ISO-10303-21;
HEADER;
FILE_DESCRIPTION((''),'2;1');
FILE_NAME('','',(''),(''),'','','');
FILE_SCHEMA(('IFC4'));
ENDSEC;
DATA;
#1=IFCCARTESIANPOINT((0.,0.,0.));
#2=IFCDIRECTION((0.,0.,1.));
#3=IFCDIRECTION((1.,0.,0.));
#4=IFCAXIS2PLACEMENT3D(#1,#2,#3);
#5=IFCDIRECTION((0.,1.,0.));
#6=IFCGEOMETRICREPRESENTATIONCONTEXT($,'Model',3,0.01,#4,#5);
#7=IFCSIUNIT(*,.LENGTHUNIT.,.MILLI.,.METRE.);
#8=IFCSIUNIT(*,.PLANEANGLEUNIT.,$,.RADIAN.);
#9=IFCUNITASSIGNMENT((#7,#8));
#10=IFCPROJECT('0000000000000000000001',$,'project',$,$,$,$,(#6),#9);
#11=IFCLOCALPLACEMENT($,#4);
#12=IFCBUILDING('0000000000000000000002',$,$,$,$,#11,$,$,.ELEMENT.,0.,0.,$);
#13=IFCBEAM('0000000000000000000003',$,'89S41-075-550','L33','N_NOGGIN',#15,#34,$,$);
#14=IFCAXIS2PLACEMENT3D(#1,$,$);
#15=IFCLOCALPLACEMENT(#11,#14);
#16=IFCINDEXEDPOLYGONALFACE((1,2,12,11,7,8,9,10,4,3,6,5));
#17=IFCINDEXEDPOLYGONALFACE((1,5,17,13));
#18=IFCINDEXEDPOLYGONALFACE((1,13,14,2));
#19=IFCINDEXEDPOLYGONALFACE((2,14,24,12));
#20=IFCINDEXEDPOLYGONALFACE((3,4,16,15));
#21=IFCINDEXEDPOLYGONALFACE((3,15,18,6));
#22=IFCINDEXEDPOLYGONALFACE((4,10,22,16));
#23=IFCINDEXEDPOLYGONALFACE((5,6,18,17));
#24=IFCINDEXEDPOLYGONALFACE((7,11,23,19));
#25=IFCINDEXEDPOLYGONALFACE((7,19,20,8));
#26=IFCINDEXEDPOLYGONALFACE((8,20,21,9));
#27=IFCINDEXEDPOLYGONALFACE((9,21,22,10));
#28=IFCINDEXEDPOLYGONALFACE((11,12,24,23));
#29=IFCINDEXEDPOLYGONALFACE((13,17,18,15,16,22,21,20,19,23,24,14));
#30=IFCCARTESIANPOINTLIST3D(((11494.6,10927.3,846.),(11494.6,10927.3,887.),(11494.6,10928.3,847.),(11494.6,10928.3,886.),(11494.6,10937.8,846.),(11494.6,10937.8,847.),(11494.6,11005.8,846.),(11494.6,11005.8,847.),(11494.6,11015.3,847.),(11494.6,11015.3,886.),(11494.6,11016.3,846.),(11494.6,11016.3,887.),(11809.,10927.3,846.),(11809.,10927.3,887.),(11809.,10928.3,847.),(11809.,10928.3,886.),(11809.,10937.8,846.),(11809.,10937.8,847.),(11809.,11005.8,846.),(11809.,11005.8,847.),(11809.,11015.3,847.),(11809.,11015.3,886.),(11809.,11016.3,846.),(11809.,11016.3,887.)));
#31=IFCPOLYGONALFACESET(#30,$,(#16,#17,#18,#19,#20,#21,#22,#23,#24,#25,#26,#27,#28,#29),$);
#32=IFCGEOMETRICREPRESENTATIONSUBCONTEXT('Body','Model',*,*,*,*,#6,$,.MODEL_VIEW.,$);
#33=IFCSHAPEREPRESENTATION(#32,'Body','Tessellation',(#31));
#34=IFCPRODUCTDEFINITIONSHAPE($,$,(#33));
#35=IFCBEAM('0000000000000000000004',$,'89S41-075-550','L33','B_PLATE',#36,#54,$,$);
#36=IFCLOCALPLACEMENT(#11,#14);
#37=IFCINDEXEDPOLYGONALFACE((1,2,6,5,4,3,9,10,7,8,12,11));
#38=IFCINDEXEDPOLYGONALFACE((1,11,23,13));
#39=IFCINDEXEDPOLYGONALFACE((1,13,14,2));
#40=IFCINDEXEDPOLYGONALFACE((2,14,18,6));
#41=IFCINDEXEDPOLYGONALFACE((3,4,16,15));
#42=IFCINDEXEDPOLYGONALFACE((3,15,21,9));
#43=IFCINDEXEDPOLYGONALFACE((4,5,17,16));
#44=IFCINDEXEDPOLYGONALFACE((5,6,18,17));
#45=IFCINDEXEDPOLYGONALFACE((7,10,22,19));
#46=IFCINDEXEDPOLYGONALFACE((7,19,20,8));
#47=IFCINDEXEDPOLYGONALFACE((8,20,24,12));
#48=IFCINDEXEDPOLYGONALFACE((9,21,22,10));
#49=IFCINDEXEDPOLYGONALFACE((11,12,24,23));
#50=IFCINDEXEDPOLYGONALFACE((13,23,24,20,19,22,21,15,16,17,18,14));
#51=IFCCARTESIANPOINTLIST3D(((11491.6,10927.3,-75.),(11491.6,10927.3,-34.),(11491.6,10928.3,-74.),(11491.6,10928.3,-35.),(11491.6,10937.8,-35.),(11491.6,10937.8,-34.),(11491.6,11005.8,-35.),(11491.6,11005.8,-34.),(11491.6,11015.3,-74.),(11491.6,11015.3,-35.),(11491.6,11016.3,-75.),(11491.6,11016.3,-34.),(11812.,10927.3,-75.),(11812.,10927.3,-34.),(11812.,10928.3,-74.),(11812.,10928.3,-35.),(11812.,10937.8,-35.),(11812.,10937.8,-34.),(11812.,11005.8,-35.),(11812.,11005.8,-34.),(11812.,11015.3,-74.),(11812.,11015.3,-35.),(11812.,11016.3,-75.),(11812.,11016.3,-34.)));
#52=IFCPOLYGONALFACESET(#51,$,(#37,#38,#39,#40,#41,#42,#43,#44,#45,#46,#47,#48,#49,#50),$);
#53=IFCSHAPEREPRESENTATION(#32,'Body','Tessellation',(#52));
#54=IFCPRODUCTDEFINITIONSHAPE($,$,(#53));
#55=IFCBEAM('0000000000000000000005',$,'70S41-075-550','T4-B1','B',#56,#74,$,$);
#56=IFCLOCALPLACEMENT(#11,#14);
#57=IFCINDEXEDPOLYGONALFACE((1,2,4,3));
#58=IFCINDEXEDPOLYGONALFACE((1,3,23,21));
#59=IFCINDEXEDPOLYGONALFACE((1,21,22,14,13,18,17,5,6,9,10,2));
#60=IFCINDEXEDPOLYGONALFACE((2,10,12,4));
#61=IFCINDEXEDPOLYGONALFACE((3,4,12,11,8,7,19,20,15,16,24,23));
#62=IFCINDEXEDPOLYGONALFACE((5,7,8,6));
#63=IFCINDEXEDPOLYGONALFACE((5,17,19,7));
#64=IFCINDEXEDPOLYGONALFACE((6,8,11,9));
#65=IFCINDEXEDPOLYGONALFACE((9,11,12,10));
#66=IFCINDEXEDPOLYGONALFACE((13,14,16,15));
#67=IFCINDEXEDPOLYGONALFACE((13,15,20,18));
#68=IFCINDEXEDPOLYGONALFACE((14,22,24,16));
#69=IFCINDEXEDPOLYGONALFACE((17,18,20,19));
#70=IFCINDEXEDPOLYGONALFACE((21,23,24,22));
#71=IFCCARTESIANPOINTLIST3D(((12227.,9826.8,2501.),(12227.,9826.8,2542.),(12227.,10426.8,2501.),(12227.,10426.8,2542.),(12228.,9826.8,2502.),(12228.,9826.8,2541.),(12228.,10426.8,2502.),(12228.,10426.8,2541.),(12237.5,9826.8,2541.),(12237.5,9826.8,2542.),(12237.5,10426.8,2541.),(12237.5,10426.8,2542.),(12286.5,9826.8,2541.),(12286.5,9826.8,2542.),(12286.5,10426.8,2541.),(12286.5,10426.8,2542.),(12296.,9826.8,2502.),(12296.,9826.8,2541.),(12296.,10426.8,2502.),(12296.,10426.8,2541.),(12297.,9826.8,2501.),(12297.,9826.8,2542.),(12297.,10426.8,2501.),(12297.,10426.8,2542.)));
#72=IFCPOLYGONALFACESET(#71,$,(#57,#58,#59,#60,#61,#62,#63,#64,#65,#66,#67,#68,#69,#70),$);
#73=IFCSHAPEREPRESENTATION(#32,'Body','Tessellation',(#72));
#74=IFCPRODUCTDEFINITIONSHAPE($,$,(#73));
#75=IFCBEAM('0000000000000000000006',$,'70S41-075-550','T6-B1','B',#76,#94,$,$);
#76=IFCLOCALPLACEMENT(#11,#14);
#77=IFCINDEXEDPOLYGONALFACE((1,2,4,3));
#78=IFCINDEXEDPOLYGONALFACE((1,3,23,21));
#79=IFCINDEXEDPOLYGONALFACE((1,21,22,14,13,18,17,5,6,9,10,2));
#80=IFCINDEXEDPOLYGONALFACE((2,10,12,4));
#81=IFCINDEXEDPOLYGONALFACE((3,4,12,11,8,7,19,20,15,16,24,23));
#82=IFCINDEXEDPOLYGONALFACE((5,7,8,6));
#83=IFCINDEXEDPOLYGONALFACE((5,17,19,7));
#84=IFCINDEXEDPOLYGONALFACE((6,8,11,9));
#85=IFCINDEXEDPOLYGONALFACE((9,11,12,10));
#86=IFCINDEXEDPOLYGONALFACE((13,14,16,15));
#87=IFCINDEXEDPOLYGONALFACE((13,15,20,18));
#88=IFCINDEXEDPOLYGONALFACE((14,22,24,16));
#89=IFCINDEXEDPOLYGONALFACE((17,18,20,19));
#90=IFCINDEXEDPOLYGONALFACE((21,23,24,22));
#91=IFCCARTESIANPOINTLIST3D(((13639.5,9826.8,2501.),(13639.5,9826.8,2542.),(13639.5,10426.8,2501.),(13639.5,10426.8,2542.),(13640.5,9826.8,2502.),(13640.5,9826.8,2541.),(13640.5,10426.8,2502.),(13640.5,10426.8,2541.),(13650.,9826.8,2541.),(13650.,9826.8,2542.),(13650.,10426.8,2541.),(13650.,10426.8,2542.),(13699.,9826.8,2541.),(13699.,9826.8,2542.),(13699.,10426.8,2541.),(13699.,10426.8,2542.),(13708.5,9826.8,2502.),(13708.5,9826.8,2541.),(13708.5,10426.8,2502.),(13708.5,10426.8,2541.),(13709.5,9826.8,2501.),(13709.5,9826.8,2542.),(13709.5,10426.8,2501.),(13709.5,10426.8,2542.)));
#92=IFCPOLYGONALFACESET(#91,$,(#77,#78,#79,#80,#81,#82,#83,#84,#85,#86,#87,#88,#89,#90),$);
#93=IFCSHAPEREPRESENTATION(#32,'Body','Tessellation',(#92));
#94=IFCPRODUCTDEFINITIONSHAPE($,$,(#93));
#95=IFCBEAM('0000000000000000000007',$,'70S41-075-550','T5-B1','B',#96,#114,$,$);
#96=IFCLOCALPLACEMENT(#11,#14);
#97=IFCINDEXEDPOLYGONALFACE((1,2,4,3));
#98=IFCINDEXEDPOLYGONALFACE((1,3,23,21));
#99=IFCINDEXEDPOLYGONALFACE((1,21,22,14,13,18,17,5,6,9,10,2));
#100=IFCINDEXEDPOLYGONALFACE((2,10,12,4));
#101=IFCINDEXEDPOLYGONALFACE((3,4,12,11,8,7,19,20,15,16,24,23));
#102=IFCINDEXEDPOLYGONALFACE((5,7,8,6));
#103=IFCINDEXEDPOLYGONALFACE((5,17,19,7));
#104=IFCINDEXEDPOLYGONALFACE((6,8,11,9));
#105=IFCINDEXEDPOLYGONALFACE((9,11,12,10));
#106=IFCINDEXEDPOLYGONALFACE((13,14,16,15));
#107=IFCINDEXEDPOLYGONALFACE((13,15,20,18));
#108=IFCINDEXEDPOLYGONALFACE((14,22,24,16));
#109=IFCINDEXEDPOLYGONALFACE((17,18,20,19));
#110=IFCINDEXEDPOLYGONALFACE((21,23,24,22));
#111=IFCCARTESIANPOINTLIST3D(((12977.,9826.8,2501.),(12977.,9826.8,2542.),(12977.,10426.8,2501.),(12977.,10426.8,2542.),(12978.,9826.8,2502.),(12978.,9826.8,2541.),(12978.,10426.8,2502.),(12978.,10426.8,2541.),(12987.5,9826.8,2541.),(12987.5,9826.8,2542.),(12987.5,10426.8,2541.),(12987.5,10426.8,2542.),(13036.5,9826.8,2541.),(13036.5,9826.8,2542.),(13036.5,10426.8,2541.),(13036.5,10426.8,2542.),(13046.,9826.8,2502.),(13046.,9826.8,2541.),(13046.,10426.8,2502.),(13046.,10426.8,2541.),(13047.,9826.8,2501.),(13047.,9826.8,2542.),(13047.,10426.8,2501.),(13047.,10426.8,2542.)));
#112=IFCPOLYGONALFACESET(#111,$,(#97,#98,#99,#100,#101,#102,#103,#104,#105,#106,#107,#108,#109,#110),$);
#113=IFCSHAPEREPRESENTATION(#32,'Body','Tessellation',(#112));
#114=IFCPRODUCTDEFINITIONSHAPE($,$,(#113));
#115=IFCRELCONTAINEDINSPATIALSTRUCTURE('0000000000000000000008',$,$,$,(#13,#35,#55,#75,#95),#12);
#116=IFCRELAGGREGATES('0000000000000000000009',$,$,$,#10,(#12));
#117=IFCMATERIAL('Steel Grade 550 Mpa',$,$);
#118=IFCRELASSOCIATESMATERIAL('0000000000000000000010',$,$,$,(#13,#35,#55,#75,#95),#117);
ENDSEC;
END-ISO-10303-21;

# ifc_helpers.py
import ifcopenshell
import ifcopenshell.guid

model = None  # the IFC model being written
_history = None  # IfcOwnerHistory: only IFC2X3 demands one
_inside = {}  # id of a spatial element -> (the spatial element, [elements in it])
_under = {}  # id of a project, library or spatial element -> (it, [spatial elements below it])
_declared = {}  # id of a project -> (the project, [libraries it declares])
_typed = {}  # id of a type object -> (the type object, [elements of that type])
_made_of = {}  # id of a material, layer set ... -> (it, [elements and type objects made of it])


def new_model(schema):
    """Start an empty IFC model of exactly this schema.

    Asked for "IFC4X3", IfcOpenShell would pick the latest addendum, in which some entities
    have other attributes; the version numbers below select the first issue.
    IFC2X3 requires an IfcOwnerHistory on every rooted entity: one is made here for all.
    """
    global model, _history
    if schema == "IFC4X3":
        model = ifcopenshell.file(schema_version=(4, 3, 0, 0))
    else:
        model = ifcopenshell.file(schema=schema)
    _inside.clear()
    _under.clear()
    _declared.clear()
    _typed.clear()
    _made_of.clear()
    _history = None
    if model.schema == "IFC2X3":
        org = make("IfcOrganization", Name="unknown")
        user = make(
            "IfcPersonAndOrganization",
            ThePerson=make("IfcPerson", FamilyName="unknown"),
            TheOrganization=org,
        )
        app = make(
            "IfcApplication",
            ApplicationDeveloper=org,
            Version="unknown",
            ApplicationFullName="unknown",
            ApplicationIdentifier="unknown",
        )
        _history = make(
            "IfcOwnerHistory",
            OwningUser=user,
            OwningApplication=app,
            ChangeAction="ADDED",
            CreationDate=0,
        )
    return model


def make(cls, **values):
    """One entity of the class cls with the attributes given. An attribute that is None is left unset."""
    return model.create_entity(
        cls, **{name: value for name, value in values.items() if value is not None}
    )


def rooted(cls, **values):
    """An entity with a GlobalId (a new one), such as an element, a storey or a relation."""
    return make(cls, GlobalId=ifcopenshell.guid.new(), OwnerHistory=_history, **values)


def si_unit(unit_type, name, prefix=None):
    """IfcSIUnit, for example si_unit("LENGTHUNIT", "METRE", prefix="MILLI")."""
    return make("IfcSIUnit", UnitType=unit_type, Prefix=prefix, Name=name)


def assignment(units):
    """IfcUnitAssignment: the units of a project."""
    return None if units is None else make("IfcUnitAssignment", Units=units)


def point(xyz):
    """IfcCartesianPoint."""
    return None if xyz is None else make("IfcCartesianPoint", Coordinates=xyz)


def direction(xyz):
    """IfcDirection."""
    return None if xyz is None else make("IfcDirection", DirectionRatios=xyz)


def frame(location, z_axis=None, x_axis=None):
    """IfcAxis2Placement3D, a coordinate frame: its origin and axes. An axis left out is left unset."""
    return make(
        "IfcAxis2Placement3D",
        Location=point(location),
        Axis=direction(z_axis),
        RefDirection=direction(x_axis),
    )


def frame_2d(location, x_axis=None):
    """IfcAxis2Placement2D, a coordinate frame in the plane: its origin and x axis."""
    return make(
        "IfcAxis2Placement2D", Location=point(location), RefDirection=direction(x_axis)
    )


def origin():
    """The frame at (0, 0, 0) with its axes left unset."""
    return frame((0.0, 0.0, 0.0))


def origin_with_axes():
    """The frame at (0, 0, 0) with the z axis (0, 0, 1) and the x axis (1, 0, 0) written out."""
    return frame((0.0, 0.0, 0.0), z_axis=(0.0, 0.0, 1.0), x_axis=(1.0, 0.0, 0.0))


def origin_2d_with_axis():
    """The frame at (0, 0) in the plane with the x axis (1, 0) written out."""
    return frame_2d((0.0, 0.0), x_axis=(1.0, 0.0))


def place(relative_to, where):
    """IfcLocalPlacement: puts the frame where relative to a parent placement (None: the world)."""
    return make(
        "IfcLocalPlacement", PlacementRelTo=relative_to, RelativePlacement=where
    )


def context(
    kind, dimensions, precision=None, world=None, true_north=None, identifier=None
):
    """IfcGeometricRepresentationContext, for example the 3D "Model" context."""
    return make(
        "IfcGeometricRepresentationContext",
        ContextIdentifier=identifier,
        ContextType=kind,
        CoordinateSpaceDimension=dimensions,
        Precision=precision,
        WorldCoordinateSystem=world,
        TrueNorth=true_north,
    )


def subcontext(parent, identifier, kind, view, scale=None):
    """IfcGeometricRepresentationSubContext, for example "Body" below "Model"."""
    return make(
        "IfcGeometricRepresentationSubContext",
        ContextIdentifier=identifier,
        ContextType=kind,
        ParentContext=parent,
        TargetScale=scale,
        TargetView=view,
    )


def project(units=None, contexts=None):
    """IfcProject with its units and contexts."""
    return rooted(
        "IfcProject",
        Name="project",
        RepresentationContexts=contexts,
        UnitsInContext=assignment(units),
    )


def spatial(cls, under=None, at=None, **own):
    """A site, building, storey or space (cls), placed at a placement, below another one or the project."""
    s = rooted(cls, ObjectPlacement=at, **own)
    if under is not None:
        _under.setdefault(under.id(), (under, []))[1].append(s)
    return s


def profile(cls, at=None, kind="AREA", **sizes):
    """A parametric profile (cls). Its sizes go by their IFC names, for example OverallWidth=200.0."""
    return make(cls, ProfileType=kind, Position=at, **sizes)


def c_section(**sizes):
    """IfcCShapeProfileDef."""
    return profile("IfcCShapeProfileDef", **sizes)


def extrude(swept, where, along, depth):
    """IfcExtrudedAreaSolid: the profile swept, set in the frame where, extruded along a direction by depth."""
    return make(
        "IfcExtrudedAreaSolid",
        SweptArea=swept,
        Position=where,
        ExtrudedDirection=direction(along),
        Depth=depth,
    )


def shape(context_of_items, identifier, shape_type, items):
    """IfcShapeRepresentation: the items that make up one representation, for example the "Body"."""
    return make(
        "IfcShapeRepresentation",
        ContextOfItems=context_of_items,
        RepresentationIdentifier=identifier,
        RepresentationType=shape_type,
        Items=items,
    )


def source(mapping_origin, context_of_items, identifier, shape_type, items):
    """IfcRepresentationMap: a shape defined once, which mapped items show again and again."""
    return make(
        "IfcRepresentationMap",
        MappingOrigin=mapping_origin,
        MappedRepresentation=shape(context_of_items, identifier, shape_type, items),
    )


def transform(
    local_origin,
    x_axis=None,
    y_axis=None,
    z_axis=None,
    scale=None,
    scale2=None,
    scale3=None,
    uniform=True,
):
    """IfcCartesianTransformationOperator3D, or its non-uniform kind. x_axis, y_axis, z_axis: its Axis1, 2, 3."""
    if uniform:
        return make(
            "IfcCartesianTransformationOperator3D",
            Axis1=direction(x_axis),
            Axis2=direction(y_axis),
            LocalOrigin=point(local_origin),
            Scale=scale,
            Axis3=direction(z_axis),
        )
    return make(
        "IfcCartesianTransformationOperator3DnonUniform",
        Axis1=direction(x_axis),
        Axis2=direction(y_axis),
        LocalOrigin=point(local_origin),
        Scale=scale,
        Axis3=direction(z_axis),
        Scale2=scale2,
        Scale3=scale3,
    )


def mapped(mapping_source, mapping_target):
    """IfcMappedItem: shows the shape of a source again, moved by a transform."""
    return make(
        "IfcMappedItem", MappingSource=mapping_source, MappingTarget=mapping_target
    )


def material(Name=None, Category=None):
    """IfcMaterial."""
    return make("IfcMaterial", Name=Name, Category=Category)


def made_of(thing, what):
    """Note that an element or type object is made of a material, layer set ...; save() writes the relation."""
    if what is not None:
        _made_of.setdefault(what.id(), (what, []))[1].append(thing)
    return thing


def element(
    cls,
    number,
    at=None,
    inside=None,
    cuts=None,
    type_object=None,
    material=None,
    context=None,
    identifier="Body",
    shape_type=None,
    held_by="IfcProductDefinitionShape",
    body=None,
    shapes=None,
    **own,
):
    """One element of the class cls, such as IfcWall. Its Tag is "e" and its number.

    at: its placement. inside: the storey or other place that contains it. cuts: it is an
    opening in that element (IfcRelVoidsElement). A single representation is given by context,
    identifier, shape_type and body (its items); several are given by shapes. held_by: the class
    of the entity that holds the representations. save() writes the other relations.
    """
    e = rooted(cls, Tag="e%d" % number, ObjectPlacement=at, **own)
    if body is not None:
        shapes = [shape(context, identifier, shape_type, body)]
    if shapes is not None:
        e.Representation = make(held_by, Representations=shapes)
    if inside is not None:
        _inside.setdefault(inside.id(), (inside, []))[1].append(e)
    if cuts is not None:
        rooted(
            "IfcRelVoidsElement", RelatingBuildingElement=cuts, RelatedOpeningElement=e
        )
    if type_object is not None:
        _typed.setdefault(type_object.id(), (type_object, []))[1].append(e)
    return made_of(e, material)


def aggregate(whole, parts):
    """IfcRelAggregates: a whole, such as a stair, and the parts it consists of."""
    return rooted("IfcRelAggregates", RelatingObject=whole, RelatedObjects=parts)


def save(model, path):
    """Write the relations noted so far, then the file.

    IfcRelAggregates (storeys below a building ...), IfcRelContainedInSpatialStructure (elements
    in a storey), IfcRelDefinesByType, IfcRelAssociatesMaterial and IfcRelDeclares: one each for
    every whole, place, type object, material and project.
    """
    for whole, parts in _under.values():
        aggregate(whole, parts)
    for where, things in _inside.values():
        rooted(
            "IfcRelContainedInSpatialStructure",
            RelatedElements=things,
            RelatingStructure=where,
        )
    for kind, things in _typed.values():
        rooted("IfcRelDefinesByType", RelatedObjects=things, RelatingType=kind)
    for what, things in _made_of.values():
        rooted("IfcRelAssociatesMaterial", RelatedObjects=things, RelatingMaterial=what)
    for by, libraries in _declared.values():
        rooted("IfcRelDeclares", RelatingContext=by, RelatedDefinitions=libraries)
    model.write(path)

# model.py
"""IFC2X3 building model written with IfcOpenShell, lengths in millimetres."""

from ifc_helpers import new_model, si_unit, direction, frame, origin, origin_with_axes, origin_2d_with_axis, place, context, subcontext, project, spatial, c_section, extrude, source, transform, mapped, material, element, save


model = new_model("IFC2X3")

# Units and contexts
model_context = context("Model", 3, precision=0.01, world=origin_with_axes(), true_north=direction((0.0, 1.0, 0.0)))
body_context = subcontext(model_context, "Body", "Model", "MODEL_VIEW")
ifc_project = project(units=[si_unit("LENGTHUNIT", "METRE", prefix="MILLI"), si_unit("PLANEANGLEUNIT", "RADIAN")], contexts=[model_context])

# Building
building_placement = place(None, origin_with_axes())
building = spatial("IfcBuilding", under=ifc_project, at=building_placement, CompositionType="ELEMENT", ElevationOfRefHeight=0.0, ElevationOfTerrain=0.0)

# Shared definitions
ifc_material = material(Name="Steel Grade 550 Mpa")

# Beams
shared_shape_1 = source(origin(), body_context, "Body", "SweptSolid", [
    extrude(c_section(Depth=89.0, Width=41.0, WallThickness=1.0, Girth=10.5, at=origin_2d_with_axis()), origin_with_axes(), (0.0, 0.0, 1.0), 314.4),
])
beam_1_placement = place(None, frame((11494.6, 10971.8, 866.5), z_axis=(1.0, 0.0, 0.0), x_axis=(0.0, 0.0, -1.0)))
element("IfcBeam", 1, at=beam_1_placement, inside=building, material=ifc_material, Name="89S41-075-550", Description="L33", ObjectType="N_NOGGIN", context=body_context, shape_type="MappedRepresentation", body=[
    mapped(shared_shape_1, transform((0.0, 0.0, 0.0), scale=1.0)),
])
shared_shape_2 = source(origin(), body_context, "Body", "SweptSolid", [
    extrude(c_section(Depth=89.0, Width=41.0, WallThickness=1.0, Girth=10.5, at=origin_2d_with_axis()), origin_with_axes(), (0.0, 0.0, 1.0), 320.4),
])
beam_2_placement = place(None, frame((11491.6, 10971.8, -54.5), z_axis=(1.0, 0.0, 0.0), x_axis=(0.0, 0.0, 1.0)))
element("IfcBeam", 2, at=beam_2_placement, inside=building, material=ifc_material, Name="89S41-075-550", Description="L33", ObjectType="B_PLATE", context=body_context, shape_type="MappedRepresentation", body=[
    mapped(shared_shape_2, transform((0.0, 0.0, 0.0), scale=1.0)),
])
shared_shape_3 = source(origin(), body_context, "Body", "SweptSolid", [
    extrude(c_section(Depth=70.0, Width=41.0, WallThickness=1.0, Girth=10.5, at=origin_2d_with_axis()), origin_with_axes(), (0.0, 0.0, 1.0), 600.0),
])
beam_3_placement = place(None, frame((12262.0, 9826.8, 2521.5), z_axis=(0.0, 1.0, 0.0), x_axis=(0.0, 0.0, 1.0)))
element("IfcBeam", 3, at=beam_3_placement, inside=building, material=ifc_material, Name="70S41-075-550", Description="T4-B1", ObjectType="B", context=body_context, shape_type="MappedRepresentation", body=[
    mapped(shared_shape_3, transform((0.0, 0.0, 0.0), scale=1.0)),
])
shared_shape_4 = source(origin(), body_context, "Body", "SweptSolid", [
    extrude(c_section(Depth=70.0, Width=41.0, WallThickness=1.0, Girth=10.5, at=origin_2d_with_axis()), origin_with_axes(), (0.0, 0.0, 1.0), 600.0),
])
beam_4_placement = place(None, frame((13674.5, 9826.8, 2521.5), z_axis=(-0.000004, 1.0, 0.0), x_axis=(0.0, 0.0, 1.0)))
element("IfcBeam", 4, at=beam_4_placement, inside=building, material=ifc_material, Name="70S41-075-550", Description="T6-B1", ObjectType="B", context=body_context, shape_type="MappedRepresentation", body=[
    mapped(shared_shape_4, transform((0.0, 0.0, 0.0), scale=1.0)),
])
shared_shape_5 = source(origin(), body_context, "Body", "SweptSolid", [
    extrude(c_section(Depth=70.0, Width=41.0, WallThickness=1.0, Girth=10.5, at=origin_2d_with_axis()), origin_with_axes(), (0.0, 0.0, 1.0), 600.0),
])
beam_5_placement = place(None, frame((13012.0, 9826.8, 2521.5), z_axis=(-0.000004, 1.0, 0.0), x_axis=(0.0, 0.0, 1.0)))
element("IfcBeam", 5, at=beam_5_placement, inside=building, material=ifc_material, Name="70S41-075-550", Description="T5-B1", ObjectType="B", context=body_context, shape_type="MappedRepresentation", body=[
    mapped(shared_shape_5, transform((0.0, 0.0, 0.0), scale=1.0)),
])

save(model, "model.ifc")
